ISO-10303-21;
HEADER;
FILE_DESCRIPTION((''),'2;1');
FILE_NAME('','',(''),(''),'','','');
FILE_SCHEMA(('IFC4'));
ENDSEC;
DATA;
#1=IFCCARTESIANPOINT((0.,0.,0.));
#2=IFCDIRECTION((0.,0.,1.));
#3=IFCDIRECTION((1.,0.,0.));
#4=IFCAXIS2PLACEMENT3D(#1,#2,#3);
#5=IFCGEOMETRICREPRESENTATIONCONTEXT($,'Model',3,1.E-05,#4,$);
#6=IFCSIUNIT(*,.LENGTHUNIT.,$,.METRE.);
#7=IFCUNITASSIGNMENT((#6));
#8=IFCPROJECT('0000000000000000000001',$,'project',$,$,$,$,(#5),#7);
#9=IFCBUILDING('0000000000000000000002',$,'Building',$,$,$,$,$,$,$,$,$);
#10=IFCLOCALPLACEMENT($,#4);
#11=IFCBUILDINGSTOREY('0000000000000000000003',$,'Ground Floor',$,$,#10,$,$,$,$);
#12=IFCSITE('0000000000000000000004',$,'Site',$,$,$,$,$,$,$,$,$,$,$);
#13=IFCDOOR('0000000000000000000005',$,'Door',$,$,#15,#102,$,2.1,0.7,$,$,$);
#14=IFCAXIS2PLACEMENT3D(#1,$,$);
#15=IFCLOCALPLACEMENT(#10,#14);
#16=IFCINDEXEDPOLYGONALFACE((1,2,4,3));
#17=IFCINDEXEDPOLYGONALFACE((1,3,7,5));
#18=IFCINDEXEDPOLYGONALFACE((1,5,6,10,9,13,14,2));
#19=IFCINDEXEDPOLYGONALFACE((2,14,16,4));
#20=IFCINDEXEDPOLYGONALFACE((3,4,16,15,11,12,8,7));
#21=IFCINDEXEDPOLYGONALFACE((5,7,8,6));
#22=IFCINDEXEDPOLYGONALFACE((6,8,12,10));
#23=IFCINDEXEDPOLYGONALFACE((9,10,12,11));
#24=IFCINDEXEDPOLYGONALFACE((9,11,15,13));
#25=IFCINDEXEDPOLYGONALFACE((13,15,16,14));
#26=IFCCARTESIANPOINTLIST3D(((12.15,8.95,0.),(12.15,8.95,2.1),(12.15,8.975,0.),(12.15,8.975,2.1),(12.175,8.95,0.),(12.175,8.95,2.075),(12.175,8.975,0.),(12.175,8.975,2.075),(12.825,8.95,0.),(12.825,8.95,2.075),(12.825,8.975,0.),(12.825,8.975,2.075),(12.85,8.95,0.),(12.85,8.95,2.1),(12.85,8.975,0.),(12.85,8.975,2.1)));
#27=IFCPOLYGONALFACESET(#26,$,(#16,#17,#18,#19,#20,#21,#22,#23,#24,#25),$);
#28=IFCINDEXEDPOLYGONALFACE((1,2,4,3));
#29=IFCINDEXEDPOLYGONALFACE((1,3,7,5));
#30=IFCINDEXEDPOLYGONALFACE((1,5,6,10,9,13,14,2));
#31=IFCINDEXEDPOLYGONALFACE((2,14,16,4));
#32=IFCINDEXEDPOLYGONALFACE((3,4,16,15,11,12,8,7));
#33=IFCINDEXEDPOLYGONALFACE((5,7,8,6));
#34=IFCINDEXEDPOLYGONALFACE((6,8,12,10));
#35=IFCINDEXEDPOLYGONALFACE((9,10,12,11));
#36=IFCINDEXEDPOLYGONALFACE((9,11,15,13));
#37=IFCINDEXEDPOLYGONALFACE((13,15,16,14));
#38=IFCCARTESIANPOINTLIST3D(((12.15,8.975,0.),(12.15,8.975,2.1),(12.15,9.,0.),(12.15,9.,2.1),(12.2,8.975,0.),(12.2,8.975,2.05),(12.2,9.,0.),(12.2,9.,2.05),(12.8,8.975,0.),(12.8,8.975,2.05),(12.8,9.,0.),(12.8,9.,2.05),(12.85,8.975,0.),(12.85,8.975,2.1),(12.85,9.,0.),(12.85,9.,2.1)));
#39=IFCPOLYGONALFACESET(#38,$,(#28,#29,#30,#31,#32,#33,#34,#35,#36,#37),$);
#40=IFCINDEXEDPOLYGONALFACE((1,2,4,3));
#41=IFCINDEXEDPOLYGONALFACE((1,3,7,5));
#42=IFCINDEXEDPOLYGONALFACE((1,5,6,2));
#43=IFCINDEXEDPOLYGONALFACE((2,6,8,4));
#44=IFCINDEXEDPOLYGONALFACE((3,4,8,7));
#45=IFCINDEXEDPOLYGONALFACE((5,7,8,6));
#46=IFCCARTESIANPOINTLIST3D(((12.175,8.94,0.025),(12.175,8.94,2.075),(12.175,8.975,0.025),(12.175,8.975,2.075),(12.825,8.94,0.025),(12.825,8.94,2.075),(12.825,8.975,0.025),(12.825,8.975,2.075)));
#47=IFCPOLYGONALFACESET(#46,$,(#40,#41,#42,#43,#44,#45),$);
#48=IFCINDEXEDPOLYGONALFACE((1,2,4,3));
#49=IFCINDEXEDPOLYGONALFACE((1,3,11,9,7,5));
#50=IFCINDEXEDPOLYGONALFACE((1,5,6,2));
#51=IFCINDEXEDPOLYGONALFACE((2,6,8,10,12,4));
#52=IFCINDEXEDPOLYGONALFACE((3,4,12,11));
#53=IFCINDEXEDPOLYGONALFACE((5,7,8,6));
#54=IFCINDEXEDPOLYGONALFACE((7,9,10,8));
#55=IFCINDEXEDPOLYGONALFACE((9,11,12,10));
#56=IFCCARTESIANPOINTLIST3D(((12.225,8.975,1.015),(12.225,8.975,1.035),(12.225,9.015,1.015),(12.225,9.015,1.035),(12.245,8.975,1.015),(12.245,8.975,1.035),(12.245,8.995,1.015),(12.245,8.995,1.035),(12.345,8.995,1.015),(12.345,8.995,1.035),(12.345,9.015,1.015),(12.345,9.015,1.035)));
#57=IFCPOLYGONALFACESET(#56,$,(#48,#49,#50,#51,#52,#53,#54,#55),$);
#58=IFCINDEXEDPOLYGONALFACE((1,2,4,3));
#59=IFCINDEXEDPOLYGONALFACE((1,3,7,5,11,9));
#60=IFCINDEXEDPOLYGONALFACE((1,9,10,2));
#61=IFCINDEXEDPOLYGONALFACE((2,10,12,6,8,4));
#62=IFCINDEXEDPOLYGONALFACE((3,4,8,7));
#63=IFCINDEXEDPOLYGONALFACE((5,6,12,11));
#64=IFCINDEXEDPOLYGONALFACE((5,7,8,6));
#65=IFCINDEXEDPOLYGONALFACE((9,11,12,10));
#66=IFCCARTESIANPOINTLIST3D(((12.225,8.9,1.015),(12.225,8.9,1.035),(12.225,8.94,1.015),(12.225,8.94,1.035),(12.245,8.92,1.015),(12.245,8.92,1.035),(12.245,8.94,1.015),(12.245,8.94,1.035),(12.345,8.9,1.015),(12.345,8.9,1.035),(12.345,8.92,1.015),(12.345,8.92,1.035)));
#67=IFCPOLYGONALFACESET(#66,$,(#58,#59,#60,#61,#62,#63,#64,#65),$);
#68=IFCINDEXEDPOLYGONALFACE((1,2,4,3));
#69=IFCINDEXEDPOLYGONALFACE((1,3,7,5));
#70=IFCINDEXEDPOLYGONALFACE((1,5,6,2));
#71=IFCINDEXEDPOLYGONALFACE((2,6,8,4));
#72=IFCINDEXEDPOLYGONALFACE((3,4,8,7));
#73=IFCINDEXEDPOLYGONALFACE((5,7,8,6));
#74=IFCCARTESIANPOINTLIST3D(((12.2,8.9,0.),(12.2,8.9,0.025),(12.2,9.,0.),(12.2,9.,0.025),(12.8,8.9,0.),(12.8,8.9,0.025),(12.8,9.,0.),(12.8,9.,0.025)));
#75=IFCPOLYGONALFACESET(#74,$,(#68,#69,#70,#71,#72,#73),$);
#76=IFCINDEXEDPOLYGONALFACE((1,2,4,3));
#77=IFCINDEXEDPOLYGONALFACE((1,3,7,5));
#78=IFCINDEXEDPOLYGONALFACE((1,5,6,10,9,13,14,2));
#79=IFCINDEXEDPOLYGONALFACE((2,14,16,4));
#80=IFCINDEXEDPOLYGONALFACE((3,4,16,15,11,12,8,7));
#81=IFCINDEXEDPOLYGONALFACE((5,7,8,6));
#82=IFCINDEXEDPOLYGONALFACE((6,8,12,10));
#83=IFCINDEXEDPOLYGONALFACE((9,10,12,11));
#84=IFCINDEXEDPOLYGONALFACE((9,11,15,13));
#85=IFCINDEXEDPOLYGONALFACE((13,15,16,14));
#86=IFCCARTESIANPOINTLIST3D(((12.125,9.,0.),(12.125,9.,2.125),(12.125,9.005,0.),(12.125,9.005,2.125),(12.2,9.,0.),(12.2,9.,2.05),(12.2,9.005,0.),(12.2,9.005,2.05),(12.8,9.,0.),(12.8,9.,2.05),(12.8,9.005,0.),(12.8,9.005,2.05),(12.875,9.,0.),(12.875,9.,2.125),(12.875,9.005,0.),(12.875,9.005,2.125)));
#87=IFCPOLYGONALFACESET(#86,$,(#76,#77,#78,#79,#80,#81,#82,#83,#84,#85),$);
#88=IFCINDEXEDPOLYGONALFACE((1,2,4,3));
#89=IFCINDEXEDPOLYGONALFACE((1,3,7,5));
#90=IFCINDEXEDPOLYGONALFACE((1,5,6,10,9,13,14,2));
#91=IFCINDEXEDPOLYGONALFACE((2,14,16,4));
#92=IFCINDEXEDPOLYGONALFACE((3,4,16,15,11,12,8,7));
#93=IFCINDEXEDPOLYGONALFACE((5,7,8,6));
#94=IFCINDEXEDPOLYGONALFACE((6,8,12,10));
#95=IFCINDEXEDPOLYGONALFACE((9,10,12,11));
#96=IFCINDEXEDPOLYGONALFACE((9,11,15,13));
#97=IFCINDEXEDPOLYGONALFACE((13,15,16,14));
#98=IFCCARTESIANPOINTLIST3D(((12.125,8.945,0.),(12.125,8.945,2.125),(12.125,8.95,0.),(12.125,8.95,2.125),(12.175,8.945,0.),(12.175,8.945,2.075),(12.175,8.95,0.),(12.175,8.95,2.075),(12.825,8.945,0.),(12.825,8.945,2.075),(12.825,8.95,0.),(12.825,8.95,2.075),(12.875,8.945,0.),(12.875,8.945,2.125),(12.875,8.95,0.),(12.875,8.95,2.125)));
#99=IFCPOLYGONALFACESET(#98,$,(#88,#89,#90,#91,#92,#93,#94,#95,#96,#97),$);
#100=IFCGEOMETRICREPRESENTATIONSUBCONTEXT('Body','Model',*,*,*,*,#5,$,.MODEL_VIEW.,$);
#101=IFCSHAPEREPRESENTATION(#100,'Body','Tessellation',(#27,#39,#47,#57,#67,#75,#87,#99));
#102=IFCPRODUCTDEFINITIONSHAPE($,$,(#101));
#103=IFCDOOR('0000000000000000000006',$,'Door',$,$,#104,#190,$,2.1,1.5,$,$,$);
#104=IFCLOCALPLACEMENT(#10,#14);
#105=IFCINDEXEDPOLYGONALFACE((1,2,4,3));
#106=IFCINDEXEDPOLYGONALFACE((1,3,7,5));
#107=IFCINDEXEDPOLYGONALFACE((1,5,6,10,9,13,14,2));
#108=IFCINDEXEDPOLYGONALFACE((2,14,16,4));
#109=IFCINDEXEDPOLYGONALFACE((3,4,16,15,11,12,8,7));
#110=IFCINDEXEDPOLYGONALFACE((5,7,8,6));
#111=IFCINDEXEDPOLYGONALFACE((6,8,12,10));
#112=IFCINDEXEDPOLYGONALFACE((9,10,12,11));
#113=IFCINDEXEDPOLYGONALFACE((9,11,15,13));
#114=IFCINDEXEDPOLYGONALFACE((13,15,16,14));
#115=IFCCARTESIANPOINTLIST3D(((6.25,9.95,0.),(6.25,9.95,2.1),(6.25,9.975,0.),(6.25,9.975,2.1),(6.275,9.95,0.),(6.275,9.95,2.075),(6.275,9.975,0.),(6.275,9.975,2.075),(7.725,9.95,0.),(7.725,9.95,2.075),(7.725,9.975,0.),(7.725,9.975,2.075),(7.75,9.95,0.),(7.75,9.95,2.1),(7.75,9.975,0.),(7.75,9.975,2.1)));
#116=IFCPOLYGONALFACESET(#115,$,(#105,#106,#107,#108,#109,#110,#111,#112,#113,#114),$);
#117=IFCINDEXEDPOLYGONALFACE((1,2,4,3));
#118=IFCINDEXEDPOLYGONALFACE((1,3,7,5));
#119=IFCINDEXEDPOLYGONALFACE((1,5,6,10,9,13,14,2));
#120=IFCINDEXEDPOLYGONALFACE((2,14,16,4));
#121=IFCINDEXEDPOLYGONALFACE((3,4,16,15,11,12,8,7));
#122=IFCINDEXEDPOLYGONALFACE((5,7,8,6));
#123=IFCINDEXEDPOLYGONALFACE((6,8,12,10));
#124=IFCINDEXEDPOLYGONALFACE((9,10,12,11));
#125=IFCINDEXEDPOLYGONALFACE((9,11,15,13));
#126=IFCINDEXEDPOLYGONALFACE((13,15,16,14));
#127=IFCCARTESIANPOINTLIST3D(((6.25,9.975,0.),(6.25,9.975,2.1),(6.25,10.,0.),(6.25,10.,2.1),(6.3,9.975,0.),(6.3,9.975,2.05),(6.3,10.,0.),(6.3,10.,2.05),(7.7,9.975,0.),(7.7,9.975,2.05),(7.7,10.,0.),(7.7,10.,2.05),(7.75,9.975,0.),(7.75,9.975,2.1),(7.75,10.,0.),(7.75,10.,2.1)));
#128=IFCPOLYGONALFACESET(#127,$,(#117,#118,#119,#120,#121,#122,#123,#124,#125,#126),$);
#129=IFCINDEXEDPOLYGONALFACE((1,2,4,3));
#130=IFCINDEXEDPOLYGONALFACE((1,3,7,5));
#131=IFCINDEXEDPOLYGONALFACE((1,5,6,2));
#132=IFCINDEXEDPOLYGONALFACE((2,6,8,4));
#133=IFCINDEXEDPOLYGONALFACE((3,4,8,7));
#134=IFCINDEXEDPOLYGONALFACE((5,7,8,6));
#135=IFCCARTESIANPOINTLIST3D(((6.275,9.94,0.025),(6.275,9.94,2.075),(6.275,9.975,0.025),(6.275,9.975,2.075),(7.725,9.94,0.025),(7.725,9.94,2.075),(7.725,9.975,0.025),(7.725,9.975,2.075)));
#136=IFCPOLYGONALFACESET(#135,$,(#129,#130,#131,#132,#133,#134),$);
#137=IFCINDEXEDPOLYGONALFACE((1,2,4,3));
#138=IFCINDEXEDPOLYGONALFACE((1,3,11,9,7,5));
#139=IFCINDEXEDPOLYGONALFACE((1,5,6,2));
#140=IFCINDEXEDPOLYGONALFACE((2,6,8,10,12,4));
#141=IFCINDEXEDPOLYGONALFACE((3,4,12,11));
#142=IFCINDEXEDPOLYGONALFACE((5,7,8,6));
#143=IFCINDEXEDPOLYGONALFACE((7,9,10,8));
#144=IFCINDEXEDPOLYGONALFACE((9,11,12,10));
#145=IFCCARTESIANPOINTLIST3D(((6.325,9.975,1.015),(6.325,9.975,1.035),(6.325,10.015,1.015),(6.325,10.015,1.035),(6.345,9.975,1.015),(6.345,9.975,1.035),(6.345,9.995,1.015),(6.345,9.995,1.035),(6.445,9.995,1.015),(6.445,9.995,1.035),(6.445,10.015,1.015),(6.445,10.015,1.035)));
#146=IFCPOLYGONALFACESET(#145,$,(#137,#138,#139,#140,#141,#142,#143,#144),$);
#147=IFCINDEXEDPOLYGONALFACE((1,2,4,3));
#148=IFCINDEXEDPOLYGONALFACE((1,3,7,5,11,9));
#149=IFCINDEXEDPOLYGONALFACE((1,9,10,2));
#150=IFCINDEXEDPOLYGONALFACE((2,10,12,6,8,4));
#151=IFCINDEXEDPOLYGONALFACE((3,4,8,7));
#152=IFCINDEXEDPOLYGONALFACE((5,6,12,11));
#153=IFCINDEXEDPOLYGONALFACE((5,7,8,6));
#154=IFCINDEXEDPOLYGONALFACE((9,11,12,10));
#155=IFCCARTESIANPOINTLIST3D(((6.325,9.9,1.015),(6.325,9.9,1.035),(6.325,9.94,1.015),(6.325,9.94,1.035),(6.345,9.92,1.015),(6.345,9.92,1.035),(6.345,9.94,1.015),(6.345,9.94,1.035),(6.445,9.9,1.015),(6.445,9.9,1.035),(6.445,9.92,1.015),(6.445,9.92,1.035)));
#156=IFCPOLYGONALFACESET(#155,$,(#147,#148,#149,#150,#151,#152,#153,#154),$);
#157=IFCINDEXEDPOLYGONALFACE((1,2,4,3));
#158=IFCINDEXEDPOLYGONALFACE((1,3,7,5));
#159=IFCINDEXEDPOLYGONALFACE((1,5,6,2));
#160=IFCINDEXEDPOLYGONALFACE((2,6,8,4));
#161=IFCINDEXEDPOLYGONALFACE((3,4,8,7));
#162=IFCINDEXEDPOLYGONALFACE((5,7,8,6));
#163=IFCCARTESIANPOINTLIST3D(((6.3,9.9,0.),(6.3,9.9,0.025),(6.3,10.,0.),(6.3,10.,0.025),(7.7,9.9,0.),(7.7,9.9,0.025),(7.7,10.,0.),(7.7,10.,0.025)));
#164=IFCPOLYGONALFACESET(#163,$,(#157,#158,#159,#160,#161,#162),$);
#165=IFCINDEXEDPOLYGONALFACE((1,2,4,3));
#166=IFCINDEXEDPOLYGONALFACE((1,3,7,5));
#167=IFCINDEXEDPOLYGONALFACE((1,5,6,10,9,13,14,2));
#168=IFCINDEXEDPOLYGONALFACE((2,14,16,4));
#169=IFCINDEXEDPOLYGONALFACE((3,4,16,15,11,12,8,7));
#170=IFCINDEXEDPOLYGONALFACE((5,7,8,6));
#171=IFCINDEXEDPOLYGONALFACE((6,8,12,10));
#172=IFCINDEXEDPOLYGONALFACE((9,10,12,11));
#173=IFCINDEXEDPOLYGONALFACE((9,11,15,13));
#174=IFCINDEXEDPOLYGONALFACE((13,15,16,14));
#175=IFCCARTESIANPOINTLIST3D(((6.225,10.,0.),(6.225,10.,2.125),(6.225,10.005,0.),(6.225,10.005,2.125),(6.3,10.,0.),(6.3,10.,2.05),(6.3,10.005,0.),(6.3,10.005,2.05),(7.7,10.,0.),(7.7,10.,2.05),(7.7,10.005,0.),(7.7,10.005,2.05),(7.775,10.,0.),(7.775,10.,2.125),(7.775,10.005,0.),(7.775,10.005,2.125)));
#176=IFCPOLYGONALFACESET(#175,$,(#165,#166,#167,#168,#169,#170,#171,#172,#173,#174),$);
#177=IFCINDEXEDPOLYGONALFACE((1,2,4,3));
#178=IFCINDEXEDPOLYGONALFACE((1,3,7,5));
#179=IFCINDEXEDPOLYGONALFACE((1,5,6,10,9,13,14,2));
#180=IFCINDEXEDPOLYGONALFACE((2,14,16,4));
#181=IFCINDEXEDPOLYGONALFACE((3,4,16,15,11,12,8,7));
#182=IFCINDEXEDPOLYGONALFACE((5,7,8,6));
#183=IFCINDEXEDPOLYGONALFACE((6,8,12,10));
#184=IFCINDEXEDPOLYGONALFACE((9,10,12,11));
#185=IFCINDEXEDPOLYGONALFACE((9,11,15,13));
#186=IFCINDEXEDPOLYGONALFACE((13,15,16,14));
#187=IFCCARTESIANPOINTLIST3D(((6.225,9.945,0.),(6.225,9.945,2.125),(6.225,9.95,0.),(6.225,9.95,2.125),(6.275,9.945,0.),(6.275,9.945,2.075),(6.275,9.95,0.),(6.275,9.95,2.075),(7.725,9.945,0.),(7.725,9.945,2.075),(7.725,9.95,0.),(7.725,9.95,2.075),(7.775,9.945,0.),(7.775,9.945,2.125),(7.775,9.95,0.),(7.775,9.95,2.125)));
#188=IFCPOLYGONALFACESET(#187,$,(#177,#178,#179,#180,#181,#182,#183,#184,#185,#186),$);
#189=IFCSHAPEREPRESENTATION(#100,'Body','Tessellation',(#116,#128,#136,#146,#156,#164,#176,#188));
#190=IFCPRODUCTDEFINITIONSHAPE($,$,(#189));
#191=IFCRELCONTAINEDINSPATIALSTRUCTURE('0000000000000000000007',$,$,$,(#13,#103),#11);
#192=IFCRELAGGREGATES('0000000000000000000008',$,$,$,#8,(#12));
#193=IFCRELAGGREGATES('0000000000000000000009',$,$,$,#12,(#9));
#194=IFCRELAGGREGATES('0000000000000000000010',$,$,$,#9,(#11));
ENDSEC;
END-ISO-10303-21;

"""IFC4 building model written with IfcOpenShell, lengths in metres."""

from ifc_helpers import new_model, si_unit, frame, origin_with_axes, place, context, subcontext, project, spatial, line, indexed_curve, outline, extrude, element, save


model = new_model("IFC4")

# Units and contexts
model_context = context("Model", 3, precision=1e-05, world=origin_with_axes())
body_context = subcontext(model_context, "Body", "Model", "MODEL_VIEW")
ifc_project = project(units=[si_unit("LENGTHUNIT", "METRE")], contexts=[model_context])

# Site, building, storey
site = spatial("IfcSite", under=ifc_project, Name="Site")
building = spatial("IfcBuilding", under=site, Name="Building")
storey_placement = place(None, origin_with_axes())
storey = spatial("IfcBuildingStorey", under=building, at=storey_placement, Name="Ground Floor")

# Doors
door_1_placement = place(storey_placement, frame((12.85, 9.0, 0.0), z_axis=(0.0, 0.0, 1.0), x_axis=(-1.0, 0.0, 0.0)))
element("IfcDoor", 1, at=door_1_placement, inside=storey, Name="Door", OverallHeight=2.1, OverallWidth=0.7, context=body_context, shape_type="SweptSolid", body=[
    extrude(outline(indexed_curve([(0.0, 0.0), (0.0, 2.1), (0.7, 2.1), (0.7, 0.0), (0.675, 0.0), (0.675, 2.075), (0.025, 2.075), (0.025, 0.0)], segments=[line(1, 2, 3, 4, 5, 6, 7, 8, 1)])), frame((0.0, 0.025, 0.0), z_axis=(0.0, -1.0, 0.0), x_axis=(1.0, 0.0, 0.0)), (0.0, 0.0, -1.0), 0.025),
    extrude(outline(indexed_curve([(0.0, 0.0), (0.0, 2.1), (0.7, 2.1), (0.7, 0.0), (0.65, 0.0), (0.65, 2.05), (0.05, 2.05), (0.05, 0.0)], segments=[line(1, 2, 3, 4, 5, 6, 7, 8, 1)])), frame((0.0, 0.0, 0.0), z_axis=(0.0, -1.0, 0.0), x_axis=(1.0, 0.0, 0.0)), (0.0, 0.0, -1.0), 0.025),
    extrude(outline(indexed_curve([(0.0, 0.0), (0.65, 0.0), (0.65, 0.035), (0.0, 0.035)], segments=[line(1, 2, 3, 4, 1)])), frame((0.025, 0.025, 0.025), z_axis=(0.0, 0.0, 1.0), x_axis=(1.0, 0.0, 0.0)), (0.0, 0.0, 1.0), 2.05),
    extrude(outline(indexed_curve([(0.0, 0.0), (0.0, -0.04), (-0.12, -0.04), (-0.12, -0.02), (-0.02, -0.02), (-0.02, 0.0)], segments=[line(1, 2, 3, 4, 5, 6, 1)])), frame((0.625, 0.025, 1.015), z_axis=(0.0, 0.0, 1.0), x_axis=(1.0, 0.0, 0.0)), (0.0, 0.0, 1.0), 0.02),
    extrude(outline(indexed_curve([(0.0, 0.0), (0.0, 0.04), (-0.12, 0.04), (-0.12, 0.02), (-0.02, 0.02), (-0.02, 0.0)], segments=[line(1, 2, 3, 4, 5, 6, 1)])), frame((0.625, 0.06, 1.015), z_axis=(0.0, 0.0, 1.0), x_axis=(1.0, 0.0, 0.0)), (0.0, 0.0, 1.0), 0.02),
    extrude(outline(indexed_curve([(0.0, 0.0), (0.6, 0.0), (0.6, 0.1), (0.0, 0.1)], segments=[line(1, 2, 3, 4, 1)])), frame((0.05, 0.0, 0.0), z_axis=(0.0, 0.0, 1.0), x_axis=(1.0, 0.0, 0.0)), (0.0, 0.0, 1.0), 0.025),
    extrude(outline(indexed_curve([(0.0, 0.0), (0.0, 2.125), (0.75, 2.125), (0.75, 0.0), (0.675, 0.0), (0.675, 2.05), (0.075, 2.05), (0.075, 0.0)], segments=[line(1, 2, 3, 4, 5, 6, 7, 8, 1)])), frame((-0.025, -0.005, 0.0), z_axis=(0.0, -1.0, 0.0), x_axis=(1.0, 0.0, 0.0)), (0.0, 0.0, -1.0), 0.005),
    extrude(outline(indexed_curve([(0.0, 0.0), (0.0, 2.125), (0.75, 2.125), (0.75, 0.0), (0.7, 0.0), (0.7, 2.075), (0.05, 2.075), (0.05, 0.0)], segments=[line(1, 2, 3, 4, 5, 6, 7, 8, 1)])), frame((-0.025, 0.05, 0.0), z_axis=(0.0, -1.0, 0.0), x_axis=(1.0, 0.0, 0.0)), (0.0, 0.0, -1.0), 0.005),
])
door_2_placement = place(storey_placement, frame((7.75, 10.0, 0.0), z_axis=(0.0, 0.0, 1.0), x_axis=(-1.0, 0.0, 0.0)))
element("IfcDoor", 2, at=door_2_placement, inside=storey, Name="Door", OverallHeight=2.1, OverallWidth=1.5, context=body_context, shape_type="SweptSolid", body=[
    extrude(outline(indexed_curve([(0.0, 0.0), (0.0, 2.1), (1.5, 2.1), (1.5, 0.0), (1.475, 0.0), (1.475, 2.075), (0.025, 2.075), (0.025, 0.0)], segments=[line(1, 2, 3, 4, 5, 6, 7, 8, 1)])), frame((0.0, 0.025, 0.0), z_axis=(0.0, -1.0, 0.0), x_axis=(1.0, 0.0, 0.0)), (0.0, 0.0, -1.0), 0.025),
    extrude(outline(indexed_curve([(0.0, 0.0), (0.0, 2.1), (1.5, 2.1), (1.5, 0.0), (1.45, 0.0), (1.45, 2.05), (0.05, 2.05), (0.05, 0.0)], segments=[line(1, 2, 3, 4, 5, 6, 7, 8, 1)])), frame((0.0, 0.0, 0.0), z_axis=(0.0, -1.0, 0.0), x_axis=(1.0, 0.0, 0.0)), (0.0, 0.0, -1.0), 0.025),
    extrude(outline(indexed_curve([(0.0, 0.0), (1.45, 0.0), (1.45, 0.035), (0.0, 0.035)], segments=[line(1, 2, 3, 4, 1)])), frame((0.025, 0.025, 0.025), z_axis=(0.0, 0.0, 1.0), x_axis=(1.0, 0.0, 0.0)), (0.0, 0.0, 1.0), 2.05),
    extrude(outline(indexed_curve([(0.0, 0.0), (0.0, -0.04), (-0.12, -0.04), (-0.12, -0.02), (-0.02, -0.02), (-0.02, 0.0)], segments=[line(1, 2, 3, 4, 5, 6, 1)])), frame((1.425, 0.025, 1.015), z_axis=(0.0, 0.0, 1.0), x_axis=(1.0, 0.0, 0.0)), (0.0, 0.0, 1.0), 0.02),
    extrude(outline(indexed_curve([(0.0, 0.0), (0.0, 0.04), (-0.12, 0.04), (-0.12, 0.02), (-0.02, 0.02), (-0.02, 0.0)], segments=[line(1, 2, 3, 4, 5, 6, 1)])), frame((1.425, 0.06, 1.015), z_axis=(0.0, 0.0, 1.0), x_axis=(1.0, 0.0, 0.0)), (0.0, 0.0, 1.0), 0.02),
    extrude(outline(indexed_curve([(0.0, 0.0), (1.4, 0.0), (1.4, 0.1), (0.0, 0.1)], segments=[line(1, 2, 3, 4, 1)])), frame((0.05, 0.0, 0.0), z_axis=(0.0, 0.0, 1.0), x_axis=(1.0, 0.0, 0.0)), (0.0, 0.0, 1.0), 0.025),
    extrude(outline(indexed_curve([(0.0, 0.0), (0.0, 2.125), (1.55, 2.125), (1.55, 0.0), (1.475, 0.0), (1.475, 2.05), (0.075, 2.05), (0.075, 0.0)], segments=[line(1, 2, 3, 4, 5, 6, 7, 8, 1)])), frame((-0.025, -0.005, 0.0), z_axis=(0.0, -1.0, 0.0), x_axis=(1.0, 0.0, 0.0)), (0.0, 0.0, -1.0), 0.005),
    extrude(outline(indexed_curve([(0.0, 0.0), (0.0, 2.125), (1.55, 2.125), (1.55, 0.0), (1.5, 0.0), (1.5, 2.075), (0.05, 2.075), (0.05, 0.0)], segments=[line(1, 2, 3, 4, 5, 6, 7, 8, 1)])), frame((-0.025, 0.05, 0.0), z_axis=(0.0, -1.0, 0.0), x_axis=(1.0, 0.0, 0.0)), (0.0, 0.0, -1.0), 0.005),
])

save(model, "model.ifc")
